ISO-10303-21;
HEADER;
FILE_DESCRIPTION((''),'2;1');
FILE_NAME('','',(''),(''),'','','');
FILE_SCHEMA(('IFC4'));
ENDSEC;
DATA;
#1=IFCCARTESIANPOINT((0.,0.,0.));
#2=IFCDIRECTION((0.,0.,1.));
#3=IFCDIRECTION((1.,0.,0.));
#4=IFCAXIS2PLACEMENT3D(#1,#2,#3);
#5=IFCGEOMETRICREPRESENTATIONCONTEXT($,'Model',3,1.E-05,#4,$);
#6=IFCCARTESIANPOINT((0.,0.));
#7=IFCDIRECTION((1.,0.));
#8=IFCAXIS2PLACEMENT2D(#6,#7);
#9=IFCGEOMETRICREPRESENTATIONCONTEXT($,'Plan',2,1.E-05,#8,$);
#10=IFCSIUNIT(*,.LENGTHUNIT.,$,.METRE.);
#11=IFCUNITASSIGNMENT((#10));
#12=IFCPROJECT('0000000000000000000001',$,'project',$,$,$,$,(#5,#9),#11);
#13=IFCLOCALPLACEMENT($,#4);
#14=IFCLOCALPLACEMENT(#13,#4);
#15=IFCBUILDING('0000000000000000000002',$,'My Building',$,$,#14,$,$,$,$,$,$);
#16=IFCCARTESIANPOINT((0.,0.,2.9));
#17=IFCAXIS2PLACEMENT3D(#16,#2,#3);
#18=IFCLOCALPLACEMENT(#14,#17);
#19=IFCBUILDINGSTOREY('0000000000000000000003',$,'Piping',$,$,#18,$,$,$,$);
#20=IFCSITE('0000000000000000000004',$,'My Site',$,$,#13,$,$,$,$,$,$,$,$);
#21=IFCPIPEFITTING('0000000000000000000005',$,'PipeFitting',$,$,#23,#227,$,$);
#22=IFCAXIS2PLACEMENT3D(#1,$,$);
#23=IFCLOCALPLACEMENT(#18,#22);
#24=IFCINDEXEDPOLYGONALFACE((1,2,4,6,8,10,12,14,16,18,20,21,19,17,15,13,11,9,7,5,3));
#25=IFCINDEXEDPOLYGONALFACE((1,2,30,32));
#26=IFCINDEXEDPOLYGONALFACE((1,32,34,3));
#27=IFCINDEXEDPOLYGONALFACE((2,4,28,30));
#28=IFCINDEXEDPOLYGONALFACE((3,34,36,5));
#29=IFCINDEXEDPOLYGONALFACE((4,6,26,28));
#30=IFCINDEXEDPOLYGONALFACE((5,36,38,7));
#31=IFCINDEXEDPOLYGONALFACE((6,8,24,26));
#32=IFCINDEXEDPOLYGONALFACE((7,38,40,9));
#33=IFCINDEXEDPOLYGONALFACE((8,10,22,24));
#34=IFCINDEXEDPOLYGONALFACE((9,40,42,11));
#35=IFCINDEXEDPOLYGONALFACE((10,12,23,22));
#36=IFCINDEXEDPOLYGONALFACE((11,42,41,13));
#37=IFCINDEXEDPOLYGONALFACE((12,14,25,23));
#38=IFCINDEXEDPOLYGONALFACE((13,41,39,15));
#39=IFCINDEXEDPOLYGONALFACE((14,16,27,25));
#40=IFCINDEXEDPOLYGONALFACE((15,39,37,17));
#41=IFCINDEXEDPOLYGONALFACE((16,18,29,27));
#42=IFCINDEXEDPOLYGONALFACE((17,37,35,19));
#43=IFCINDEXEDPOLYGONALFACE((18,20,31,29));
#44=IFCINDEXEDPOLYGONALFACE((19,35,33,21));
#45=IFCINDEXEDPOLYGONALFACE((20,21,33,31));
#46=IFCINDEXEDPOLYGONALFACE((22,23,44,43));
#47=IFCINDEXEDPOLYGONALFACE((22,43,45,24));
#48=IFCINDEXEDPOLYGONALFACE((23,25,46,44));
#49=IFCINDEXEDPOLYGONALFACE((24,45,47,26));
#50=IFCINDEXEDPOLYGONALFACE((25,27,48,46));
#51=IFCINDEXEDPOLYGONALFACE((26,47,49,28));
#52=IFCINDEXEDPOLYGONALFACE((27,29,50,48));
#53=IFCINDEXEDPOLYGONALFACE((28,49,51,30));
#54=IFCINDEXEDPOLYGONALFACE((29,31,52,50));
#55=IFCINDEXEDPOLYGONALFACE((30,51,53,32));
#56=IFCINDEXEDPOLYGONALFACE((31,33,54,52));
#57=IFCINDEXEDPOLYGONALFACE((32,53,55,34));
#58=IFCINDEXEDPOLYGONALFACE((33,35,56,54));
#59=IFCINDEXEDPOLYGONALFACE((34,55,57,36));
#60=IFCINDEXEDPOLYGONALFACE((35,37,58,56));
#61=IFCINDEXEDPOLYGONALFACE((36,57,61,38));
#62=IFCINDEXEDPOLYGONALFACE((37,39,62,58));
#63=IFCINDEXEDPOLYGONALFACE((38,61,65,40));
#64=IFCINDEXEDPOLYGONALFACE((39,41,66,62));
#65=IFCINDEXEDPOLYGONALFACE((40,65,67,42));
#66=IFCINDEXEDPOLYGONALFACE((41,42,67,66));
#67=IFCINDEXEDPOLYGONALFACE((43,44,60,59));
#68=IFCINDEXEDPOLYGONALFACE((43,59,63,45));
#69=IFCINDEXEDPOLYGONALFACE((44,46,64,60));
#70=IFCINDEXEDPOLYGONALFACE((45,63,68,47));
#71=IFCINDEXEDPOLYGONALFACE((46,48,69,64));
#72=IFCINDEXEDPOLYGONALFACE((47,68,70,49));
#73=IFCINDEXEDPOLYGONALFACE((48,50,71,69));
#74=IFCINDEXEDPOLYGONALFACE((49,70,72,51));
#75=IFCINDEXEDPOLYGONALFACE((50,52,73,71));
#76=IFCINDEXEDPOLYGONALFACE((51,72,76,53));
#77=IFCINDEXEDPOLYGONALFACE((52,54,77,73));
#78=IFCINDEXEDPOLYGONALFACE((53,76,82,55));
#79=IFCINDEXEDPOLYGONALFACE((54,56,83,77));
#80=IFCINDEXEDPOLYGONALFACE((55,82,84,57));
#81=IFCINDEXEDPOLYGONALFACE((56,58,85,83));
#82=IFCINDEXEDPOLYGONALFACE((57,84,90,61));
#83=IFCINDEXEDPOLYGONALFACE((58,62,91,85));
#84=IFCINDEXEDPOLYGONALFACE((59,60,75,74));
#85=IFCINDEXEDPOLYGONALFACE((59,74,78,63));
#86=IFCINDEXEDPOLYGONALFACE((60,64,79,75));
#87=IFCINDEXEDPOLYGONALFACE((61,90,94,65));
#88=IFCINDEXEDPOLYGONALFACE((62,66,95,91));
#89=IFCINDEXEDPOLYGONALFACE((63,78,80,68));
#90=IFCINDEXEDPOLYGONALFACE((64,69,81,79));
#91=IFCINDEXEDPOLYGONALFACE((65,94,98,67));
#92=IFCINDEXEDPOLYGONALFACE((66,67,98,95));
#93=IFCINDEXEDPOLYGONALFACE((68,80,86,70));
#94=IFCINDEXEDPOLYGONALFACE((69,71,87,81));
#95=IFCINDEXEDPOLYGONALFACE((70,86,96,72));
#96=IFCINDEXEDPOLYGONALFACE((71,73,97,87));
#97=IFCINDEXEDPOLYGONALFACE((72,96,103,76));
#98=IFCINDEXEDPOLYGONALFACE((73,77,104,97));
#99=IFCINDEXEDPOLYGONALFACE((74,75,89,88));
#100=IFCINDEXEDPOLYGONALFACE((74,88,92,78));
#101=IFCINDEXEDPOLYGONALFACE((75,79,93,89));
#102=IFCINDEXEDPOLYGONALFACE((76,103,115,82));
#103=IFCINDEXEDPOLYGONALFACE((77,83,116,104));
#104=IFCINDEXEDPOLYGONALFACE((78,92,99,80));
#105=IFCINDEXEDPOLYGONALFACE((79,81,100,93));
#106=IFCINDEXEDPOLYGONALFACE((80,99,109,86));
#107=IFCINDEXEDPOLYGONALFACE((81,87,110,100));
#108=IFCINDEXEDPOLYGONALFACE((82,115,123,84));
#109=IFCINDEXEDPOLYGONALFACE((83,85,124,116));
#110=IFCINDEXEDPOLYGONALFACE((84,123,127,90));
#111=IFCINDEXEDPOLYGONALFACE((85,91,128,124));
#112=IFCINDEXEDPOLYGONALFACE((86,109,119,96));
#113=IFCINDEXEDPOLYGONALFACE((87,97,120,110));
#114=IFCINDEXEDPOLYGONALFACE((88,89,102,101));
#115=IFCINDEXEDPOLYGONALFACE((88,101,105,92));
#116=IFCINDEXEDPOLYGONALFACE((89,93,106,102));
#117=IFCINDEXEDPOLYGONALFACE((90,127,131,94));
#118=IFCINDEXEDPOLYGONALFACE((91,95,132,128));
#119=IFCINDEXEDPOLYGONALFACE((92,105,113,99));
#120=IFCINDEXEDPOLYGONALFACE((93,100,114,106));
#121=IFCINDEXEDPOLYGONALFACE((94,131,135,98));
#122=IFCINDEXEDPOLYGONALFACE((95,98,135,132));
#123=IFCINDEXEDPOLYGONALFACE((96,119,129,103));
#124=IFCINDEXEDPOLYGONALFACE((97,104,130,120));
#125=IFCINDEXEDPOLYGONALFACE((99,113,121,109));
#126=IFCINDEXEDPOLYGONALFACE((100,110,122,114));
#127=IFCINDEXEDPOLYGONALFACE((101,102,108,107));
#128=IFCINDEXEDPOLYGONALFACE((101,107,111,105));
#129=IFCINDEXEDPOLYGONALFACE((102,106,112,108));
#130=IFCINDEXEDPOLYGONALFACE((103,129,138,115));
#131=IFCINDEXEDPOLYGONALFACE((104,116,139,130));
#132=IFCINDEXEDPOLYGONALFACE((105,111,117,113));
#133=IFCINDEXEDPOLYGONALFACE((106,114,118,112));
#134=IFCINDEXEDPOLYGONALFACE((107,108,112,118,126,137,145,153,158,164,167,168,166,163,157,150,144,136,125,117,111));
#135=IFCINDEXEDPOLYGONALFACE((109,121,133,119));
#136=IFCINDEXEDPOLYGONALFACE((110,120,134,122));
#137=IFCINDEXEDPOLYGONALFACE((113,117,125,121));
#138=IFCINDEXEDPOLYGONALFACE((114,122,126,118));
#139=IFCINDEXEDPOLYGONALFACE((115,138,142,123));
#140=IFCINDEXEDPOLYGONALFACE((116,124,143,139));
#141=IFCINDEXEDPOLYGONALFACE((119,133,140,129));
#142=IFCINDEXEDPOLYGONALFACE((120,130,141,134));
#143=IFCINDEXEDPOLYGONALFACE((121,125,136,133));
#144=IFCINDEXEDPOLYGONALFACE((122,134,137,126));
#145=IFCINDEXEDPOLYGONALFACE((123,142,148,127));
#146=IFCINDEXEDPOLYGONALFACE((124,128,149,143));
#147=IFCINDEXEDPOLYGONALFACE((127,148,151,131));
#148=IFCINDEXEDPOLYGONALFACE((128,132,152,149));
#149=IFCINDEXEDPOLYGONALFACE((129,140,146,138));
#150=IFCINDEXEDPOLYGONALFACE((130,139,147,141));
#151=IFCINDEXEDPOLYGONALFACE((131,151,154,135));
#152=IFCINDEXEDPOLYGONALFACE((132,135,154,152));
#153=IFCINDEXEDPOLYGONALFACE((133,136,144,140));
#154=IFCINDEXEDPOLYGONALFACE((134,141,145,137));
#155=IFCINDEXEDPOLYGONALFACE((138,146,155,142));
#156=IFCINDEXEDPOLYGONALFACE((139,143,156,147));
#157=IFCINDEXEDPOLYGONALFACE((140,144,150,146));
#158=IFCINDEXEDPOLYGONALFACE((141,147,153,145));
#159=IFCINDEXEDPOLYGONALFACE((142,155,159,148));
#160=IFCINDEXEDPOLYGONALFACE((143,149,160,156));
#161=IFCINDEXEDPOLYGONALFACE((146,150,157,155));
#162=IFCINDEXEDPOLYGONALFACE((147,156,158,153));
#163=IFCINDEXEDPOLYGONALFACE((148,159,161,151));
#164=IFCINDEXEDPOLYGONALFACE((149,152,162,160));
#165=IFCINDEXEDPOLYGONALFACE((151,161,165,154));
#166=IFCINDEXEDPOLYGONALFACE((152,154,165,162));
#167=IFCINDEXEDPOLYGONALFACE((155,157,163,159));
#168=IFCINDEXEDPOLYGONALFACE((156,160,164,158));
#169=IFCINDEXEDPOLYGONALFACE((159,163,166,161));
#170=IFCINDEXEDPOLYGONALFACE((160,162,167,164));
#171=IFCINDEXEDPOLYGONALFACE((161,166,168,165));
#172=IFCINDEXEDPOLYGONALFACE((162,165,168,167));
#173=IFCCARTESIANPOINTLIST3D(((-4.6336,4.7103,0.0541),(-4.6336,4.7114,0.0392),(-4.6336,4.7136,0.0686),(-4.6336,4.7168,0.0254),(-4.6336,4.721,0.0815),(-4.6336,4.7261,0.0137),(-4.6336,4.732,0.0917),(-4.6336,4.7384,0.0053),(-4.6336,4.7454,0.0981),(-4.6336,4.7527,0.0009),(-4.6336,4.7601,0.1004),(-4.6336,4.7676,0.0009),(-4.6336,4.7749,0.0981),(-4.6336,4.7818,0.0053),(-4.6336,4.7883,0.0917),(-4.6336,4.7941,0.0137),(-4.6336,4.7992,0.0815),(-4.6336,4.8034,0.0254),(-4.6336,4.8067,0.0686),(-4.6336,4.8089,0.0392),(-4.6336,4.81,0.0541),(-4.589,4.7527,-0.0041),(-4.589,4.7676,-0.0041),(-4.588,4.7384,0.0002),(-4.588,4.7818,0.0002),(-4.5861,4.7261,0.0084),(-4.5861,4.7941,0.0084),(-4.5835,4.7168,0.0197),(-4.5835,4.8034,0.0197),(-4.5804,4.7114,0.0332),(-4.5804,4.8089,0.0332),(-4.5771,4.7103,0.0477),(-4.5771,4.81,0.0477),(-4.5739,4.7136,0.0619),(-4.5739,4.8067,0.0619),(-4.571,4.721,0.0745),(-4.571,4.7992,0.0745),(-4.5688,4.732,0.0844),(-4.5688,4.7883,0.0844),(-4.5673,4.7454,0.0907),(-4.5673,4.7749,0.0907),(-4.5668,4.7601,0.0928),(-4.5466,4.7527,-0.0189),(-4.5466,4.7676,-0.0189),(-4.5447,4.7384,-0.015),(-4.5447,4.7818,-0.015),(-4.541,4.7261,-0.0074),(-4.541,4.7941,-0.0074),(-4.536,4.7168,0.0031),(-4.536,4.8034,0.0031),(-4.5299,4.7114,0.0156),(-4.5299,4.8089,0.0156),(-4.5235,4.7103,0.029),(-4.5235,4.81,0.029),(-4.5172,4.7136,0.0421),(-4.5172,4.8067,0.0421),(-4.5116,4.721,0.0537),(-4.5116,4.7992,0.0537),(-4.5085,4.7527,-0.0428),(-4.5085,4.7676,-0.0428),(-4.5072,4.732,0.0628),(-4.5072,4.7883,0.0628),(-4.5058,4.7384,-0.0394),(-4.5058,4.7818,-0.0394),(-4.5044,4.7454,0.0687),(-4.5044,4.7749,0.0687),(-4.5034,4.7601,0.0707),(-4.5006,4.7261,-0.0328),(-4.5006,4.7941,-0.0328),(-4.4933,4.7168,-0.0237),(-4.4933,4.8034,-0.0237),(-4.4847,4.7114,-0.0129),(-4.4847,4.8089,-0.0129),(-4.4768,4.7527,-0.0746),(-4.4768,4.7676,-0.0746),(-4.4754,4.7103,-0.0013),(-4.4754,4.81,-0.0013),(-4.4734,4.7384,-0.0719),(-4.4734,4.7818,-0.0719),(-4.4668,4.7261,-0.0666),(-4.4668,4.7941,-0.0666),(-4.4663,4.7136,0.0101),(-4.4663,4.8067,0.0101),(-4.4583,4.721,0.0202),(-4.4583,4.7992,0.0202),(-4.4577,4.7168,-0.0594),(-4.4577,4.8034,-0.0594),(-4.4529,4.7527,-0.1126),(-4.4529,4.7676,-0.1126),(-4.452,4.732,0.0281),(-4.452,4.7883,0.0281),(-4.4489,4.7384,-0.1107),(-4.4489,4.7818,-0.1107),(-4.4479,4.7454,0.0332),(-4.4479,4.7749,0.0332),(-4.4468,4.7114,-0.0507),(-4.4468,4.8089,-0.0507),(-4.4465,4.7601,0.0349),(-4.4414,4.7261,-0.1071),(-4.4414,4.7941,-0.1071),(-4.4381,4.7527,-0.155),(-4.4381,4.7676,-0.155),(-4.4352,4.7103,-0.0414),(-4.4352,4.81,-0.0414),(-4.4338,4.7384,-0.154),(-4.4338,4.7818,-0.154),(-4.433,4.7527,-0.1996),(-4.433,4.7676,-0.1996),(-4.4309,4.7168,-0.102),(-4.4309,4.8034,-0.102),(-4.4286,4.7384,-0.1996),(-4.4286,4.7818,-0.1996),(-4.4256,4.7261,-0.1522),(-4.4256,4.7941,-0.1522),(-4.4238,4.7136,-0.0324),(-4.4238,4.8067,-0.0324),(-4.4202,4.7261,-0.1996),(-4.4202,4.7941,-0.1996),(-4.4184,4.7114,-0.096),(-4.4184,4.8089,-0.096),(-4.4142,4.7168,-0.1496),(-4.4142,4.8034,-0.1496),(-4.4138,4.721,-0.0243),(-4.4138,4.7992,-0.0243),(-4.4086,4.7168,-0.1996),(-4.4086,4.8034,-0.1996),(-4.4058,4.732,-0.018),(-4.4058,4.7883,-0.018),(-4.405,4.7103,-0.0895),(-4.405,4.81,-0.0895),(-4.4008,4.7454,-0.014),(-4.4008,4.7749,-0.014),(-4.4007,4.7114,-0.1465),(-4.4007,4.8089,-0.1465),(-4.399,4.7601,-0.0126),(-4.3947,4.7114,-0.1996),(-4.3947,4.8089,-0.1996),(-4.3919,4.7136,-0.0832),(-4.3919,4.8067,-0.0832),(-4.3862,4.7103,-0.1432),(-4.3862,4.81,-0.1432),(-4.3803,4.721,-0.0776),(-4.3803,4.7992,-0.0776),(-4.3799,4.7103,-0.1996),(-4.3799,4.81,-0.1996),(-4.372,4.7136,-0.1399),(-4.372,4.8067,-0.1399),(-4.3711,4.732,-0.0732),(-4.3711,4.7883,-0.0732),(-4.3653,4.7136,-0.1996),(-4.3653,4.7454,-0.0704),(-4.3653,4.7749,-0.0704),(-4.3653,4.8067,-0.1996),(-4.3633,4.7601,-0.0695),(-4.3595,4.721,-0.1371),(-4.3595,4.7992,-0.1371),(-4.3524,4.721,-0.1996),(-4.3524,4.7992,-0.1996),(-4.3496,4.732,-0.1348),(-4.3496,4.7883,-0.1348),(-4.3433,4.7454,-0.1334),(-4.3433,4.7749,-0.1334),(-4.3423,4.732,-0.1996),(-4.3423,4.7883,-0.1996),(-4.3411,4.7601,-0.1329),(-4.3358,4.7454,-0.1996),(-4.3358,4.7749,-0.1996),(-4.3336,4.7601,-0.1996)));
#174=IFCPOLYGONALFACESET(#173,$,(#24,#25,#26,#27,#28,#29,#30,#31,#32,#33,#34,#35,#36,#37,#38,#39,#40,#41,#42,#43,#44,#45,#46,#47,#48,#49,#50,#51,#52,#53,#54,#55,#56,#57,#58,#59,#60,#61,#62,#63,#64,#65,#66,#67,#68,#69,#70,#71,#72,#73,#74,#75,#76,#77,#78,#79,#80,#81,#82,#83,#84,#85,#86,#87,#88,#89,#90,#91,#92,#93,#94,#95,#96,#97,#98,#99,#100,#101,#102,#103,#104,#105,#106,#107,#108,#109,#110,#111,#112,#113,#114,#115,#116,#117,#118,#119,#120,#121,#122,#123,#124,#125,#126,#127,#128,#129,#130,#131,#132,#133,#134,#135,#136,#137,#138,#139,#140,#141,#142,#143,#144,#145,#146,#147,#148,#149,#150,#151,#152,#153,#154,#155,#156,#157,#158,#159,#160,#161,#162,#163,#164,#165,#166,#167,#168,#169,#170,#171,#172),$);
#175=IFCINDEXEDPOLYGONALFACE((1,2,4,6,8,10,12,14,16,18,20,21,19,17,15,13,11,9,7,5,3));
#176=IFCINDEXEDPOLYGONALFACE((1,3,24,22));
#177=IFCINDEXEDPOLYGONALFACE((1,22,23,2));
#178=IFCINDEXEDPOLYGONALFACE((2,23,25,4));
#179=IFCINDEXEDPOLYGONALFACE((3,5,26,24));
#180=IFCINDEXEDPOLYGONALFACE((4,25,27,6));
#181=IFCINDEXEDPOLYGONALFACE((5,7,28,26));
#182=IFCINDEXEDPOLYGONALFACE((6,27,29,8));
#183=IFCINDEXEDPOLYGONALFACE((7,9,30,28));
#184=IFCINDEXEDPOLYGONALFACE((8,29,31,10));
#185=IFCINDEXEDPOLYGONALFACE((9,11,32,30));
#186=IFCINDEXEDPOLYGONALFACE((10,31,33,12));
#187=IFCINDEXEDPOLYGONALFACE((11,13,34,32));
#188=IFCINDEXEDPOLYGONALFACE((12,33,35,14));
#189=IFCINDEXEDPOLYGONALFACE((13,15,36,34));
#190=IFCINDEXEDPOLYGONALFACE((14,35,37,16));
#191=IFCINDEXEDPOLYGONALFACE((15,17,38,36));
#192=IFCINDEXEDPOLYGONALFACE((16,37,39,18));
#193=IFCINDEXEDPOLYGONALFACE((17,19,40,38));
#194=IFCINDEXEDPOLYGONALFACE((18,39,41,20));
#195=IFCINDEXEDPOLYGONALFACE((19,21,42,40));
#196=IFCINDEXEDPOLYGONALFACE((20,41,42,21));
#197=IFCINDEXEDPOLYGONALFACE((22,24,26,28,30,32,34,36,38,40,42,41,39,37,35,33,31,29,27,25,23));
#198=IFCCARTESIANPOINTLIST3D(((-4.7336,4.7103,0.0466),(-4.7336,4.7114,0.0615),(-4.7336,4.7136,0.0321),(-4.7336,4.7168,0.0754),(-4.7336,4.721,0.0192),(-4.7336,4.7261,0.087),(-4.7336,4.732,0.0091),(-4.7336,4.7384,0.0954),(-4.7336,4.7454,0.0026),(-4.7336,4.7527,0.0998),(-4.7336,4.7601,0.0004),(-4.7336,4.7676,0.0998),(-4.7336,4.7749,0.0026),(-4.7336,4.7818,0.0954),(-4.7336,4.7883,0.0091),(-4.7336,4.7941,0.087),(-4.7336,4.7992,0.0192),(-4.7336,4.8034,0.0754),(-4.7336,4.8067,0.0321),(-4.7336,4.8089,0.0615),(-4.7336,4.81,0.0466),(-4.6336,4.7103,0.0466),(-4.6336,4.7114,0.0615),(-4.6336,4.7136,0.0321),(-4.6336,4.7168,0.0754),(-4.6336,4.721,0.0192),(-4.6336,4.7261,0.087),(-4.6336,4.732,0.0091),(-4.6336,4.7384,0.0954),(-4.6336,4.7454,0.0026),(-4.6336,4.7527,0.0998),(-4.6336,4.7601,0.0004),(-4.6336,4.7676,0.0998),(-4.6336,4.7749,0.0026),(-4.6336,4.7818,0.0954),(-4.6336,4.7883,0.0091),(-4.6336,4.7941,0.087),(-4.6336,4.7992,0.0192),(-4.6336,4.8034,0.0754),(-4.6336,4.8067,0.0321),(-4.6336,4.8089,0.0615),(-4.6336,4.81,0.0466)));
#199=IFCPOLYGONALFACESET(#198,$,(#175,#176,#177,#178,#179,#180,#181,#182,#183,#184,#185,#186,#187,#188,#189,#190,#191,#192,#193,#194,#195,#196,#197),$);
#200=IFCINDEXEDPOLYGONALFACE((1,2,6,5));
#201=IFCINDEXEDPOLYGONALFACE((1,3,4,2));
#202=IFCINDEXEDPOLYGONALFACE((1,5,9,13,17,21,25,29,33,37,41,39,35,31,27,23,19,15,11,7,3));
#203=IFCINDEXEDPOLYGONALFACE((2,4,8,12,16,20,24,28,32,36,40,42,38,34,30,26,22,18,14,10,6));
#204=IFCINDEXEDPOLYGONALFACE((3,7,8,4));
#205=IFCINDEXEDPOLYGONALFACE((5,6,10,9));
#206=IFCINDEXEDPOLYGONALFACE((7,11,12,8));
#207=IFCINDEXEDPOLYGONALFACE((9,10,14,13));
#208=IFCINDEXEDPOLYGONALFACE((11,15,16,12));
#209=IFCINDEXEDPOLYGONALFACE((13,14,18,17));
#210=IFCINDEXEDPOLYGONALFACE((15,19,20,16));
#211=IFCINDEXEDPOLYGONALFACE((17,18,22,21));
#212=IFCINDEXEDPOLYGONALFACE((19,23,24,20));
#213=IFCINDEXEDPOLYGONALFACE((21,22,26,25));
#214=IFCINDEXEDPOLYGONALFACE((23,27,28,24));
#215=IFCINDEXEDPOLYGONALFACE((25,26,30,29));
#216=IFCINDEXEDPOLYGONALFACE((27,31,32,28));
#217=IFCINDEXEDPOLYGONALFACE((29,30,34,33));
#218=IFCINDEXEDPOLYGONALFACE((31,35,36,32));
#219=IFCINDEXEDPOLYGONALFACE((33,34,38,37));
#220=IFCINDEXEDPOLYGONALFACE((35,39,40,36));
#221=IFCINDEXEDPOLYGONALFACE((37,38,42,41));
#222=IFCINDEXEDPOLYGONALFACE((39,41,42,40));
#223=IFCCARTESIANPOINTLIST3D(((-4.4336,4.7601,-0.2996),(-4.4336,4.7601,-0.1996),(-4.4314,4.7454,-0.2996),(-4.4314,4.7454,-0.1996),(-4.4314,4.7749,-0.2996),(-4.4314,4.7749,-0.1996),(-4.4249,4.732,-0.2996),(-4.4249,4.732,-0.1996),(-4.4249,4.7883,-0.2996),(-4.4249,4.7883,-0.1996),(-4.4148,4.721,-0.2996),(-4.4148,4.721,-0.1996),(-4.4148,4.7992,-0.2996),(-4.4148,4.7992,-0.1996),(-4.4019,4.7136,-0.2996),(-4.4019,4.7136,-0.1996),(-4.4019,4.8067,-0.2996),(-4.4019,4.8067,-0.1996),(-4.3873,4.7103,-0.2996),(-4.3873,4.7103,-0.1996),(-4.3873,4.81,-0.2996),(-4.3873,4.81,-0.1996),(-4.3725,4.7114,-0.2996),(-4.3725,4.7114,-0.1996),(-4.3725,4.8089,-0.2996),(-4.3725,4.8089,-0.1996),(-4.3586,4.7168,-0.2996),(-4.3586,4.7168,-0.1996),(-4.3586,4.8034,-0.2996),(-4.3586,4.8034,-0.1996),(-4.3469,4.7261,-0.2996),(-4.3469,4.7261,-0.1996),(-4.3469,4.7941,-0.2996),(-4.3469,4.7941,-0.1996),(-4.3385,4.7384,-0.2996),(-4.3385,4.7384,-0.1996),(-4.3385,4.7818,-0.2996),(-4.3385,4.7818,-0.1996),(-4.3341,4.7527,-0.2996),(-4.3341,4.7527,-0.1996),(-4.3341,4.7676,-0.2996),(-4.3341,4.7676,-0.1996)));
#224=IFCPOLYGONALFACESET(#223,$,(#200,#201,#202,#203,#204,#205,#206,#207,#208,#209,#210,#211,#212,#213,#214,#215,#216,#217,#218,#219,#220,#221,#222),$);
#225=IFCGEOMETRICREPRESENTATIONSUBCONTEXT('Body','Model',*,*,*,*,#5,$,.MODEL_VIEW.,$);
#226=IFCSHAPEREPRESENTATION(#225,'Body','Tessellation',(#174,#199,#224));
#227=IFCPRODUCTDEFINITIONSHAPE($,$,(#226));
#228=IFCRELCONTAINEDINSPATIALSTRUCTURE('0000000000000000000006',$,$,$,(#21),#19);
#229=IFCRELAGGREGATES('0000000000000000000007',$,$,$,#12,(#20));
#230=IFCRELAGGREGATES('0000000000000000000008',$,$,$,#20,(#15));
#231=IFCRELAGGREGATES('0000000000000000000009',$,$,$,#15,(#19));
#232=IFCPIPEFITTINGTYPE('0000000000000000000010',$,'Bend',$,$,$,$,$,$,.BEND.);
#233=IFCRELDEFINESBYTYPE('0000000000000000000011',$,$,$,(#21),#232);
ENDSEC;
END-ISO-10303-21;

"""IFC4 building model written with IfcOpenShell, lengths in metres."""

from ifc_helpers import new_model, entity, si_unit, frame, origin_with_axes, origin_2d_with_axis, place, context, subcontext, project, spatial, circle, extrude, source, transform, mapped, type_object, type_shapes, element, save


model = new_model("IFC4")

# Units and contexts
model_context = context("Model", 3, precision=1e-05, world=origin_with_axes())
plan_context = context("Plan", 2, precision=1e-05, world=origin_2d_with_axis())
body_context = subcontext(model_context, "Body", "Model", "MODEL_VIEW")
ifc_project = project(units=[si_unit("LENGTHUNIT", "METRE")], contexts=[model_context, plan_context])

# Site, building, storey
site_placement = place(None, origin_with_axes())
site = spatial("IfcSite", under=ifc_project, at=site_placement, Name="My Site")
building_placement = place(site_placement, origin_with_axes())
building = spatial("IfcBuilding", under=site, at=building_placement, Name="My Building")
storey_placement = place(building_placement, frame((0.0, 0.0, 2.9), z_axis=(0.0, 0.0, 1.0), x_axis=(1.0, 0.0, 0.0)))
storey = spatial("IfcBuildingStorey", under=building, at=storey_placement, Name="Piping")

# Pipe fitting
pipe_fitting_type_1 = type_object("IfcPipeFittingType", Name="Bend", PredefinedType="BEND")
shared_shape = source(origin_with_axes(), body_context, "Body", "SolidModel", [
    entity("IfcSweptDiskSolid", entity("IfcIndexedPolyCurve", entity("IfcCartesianPointList3D", [[0.0, 0.0, -0.1], [0.0732, 0.0, -0.2768], [0.25, 0.0, -0.35]]), [entity("IfcArcIndex", [1, 2, 3])]), 0.05),
    extrude(circle(Radius=0.05), origin_with_axes(), (0.0, 0.0, -1.0), 0.1),
    extrude(circle(Radius=0.05), frame((0.25, 0.0, -0.35), z_axis=(1.0, 0.0, 0.0), x_axis=(0.0, 0.0, 1.0)), (0.0, 0.0, 1.0), 0.1),
])
type_shapes(pipe_fitting_type_1, [shared_shape])
for number, where, z_axis, x_axis, name in (
    (1, (-4.7336, 4.7601, 0.0504), (-1.0, 0.0, 0.0), (0.0, 0.0, -1.0), "PipeFitting"),
):
    element("IfcPipeFitting", number, at=place(storey_placement, frame(where, z_axis=z_axis, x_axis=x_axis)), inside=storey, type_object=pipe_fitting_type_1, Name=name, context=body_context, shape_type="MappedRepresentation", body=[
        mapped(shared_shape, transform((0.0, 0.0, 0.0), x_axis=(1.0, 0.0, 0.0), y_axis=(0.0, 1.0, 0.0), z_axis=(0.0, 0.0, 1.0), scale=1.0)),
    ])

save(model, "model.ifc")
